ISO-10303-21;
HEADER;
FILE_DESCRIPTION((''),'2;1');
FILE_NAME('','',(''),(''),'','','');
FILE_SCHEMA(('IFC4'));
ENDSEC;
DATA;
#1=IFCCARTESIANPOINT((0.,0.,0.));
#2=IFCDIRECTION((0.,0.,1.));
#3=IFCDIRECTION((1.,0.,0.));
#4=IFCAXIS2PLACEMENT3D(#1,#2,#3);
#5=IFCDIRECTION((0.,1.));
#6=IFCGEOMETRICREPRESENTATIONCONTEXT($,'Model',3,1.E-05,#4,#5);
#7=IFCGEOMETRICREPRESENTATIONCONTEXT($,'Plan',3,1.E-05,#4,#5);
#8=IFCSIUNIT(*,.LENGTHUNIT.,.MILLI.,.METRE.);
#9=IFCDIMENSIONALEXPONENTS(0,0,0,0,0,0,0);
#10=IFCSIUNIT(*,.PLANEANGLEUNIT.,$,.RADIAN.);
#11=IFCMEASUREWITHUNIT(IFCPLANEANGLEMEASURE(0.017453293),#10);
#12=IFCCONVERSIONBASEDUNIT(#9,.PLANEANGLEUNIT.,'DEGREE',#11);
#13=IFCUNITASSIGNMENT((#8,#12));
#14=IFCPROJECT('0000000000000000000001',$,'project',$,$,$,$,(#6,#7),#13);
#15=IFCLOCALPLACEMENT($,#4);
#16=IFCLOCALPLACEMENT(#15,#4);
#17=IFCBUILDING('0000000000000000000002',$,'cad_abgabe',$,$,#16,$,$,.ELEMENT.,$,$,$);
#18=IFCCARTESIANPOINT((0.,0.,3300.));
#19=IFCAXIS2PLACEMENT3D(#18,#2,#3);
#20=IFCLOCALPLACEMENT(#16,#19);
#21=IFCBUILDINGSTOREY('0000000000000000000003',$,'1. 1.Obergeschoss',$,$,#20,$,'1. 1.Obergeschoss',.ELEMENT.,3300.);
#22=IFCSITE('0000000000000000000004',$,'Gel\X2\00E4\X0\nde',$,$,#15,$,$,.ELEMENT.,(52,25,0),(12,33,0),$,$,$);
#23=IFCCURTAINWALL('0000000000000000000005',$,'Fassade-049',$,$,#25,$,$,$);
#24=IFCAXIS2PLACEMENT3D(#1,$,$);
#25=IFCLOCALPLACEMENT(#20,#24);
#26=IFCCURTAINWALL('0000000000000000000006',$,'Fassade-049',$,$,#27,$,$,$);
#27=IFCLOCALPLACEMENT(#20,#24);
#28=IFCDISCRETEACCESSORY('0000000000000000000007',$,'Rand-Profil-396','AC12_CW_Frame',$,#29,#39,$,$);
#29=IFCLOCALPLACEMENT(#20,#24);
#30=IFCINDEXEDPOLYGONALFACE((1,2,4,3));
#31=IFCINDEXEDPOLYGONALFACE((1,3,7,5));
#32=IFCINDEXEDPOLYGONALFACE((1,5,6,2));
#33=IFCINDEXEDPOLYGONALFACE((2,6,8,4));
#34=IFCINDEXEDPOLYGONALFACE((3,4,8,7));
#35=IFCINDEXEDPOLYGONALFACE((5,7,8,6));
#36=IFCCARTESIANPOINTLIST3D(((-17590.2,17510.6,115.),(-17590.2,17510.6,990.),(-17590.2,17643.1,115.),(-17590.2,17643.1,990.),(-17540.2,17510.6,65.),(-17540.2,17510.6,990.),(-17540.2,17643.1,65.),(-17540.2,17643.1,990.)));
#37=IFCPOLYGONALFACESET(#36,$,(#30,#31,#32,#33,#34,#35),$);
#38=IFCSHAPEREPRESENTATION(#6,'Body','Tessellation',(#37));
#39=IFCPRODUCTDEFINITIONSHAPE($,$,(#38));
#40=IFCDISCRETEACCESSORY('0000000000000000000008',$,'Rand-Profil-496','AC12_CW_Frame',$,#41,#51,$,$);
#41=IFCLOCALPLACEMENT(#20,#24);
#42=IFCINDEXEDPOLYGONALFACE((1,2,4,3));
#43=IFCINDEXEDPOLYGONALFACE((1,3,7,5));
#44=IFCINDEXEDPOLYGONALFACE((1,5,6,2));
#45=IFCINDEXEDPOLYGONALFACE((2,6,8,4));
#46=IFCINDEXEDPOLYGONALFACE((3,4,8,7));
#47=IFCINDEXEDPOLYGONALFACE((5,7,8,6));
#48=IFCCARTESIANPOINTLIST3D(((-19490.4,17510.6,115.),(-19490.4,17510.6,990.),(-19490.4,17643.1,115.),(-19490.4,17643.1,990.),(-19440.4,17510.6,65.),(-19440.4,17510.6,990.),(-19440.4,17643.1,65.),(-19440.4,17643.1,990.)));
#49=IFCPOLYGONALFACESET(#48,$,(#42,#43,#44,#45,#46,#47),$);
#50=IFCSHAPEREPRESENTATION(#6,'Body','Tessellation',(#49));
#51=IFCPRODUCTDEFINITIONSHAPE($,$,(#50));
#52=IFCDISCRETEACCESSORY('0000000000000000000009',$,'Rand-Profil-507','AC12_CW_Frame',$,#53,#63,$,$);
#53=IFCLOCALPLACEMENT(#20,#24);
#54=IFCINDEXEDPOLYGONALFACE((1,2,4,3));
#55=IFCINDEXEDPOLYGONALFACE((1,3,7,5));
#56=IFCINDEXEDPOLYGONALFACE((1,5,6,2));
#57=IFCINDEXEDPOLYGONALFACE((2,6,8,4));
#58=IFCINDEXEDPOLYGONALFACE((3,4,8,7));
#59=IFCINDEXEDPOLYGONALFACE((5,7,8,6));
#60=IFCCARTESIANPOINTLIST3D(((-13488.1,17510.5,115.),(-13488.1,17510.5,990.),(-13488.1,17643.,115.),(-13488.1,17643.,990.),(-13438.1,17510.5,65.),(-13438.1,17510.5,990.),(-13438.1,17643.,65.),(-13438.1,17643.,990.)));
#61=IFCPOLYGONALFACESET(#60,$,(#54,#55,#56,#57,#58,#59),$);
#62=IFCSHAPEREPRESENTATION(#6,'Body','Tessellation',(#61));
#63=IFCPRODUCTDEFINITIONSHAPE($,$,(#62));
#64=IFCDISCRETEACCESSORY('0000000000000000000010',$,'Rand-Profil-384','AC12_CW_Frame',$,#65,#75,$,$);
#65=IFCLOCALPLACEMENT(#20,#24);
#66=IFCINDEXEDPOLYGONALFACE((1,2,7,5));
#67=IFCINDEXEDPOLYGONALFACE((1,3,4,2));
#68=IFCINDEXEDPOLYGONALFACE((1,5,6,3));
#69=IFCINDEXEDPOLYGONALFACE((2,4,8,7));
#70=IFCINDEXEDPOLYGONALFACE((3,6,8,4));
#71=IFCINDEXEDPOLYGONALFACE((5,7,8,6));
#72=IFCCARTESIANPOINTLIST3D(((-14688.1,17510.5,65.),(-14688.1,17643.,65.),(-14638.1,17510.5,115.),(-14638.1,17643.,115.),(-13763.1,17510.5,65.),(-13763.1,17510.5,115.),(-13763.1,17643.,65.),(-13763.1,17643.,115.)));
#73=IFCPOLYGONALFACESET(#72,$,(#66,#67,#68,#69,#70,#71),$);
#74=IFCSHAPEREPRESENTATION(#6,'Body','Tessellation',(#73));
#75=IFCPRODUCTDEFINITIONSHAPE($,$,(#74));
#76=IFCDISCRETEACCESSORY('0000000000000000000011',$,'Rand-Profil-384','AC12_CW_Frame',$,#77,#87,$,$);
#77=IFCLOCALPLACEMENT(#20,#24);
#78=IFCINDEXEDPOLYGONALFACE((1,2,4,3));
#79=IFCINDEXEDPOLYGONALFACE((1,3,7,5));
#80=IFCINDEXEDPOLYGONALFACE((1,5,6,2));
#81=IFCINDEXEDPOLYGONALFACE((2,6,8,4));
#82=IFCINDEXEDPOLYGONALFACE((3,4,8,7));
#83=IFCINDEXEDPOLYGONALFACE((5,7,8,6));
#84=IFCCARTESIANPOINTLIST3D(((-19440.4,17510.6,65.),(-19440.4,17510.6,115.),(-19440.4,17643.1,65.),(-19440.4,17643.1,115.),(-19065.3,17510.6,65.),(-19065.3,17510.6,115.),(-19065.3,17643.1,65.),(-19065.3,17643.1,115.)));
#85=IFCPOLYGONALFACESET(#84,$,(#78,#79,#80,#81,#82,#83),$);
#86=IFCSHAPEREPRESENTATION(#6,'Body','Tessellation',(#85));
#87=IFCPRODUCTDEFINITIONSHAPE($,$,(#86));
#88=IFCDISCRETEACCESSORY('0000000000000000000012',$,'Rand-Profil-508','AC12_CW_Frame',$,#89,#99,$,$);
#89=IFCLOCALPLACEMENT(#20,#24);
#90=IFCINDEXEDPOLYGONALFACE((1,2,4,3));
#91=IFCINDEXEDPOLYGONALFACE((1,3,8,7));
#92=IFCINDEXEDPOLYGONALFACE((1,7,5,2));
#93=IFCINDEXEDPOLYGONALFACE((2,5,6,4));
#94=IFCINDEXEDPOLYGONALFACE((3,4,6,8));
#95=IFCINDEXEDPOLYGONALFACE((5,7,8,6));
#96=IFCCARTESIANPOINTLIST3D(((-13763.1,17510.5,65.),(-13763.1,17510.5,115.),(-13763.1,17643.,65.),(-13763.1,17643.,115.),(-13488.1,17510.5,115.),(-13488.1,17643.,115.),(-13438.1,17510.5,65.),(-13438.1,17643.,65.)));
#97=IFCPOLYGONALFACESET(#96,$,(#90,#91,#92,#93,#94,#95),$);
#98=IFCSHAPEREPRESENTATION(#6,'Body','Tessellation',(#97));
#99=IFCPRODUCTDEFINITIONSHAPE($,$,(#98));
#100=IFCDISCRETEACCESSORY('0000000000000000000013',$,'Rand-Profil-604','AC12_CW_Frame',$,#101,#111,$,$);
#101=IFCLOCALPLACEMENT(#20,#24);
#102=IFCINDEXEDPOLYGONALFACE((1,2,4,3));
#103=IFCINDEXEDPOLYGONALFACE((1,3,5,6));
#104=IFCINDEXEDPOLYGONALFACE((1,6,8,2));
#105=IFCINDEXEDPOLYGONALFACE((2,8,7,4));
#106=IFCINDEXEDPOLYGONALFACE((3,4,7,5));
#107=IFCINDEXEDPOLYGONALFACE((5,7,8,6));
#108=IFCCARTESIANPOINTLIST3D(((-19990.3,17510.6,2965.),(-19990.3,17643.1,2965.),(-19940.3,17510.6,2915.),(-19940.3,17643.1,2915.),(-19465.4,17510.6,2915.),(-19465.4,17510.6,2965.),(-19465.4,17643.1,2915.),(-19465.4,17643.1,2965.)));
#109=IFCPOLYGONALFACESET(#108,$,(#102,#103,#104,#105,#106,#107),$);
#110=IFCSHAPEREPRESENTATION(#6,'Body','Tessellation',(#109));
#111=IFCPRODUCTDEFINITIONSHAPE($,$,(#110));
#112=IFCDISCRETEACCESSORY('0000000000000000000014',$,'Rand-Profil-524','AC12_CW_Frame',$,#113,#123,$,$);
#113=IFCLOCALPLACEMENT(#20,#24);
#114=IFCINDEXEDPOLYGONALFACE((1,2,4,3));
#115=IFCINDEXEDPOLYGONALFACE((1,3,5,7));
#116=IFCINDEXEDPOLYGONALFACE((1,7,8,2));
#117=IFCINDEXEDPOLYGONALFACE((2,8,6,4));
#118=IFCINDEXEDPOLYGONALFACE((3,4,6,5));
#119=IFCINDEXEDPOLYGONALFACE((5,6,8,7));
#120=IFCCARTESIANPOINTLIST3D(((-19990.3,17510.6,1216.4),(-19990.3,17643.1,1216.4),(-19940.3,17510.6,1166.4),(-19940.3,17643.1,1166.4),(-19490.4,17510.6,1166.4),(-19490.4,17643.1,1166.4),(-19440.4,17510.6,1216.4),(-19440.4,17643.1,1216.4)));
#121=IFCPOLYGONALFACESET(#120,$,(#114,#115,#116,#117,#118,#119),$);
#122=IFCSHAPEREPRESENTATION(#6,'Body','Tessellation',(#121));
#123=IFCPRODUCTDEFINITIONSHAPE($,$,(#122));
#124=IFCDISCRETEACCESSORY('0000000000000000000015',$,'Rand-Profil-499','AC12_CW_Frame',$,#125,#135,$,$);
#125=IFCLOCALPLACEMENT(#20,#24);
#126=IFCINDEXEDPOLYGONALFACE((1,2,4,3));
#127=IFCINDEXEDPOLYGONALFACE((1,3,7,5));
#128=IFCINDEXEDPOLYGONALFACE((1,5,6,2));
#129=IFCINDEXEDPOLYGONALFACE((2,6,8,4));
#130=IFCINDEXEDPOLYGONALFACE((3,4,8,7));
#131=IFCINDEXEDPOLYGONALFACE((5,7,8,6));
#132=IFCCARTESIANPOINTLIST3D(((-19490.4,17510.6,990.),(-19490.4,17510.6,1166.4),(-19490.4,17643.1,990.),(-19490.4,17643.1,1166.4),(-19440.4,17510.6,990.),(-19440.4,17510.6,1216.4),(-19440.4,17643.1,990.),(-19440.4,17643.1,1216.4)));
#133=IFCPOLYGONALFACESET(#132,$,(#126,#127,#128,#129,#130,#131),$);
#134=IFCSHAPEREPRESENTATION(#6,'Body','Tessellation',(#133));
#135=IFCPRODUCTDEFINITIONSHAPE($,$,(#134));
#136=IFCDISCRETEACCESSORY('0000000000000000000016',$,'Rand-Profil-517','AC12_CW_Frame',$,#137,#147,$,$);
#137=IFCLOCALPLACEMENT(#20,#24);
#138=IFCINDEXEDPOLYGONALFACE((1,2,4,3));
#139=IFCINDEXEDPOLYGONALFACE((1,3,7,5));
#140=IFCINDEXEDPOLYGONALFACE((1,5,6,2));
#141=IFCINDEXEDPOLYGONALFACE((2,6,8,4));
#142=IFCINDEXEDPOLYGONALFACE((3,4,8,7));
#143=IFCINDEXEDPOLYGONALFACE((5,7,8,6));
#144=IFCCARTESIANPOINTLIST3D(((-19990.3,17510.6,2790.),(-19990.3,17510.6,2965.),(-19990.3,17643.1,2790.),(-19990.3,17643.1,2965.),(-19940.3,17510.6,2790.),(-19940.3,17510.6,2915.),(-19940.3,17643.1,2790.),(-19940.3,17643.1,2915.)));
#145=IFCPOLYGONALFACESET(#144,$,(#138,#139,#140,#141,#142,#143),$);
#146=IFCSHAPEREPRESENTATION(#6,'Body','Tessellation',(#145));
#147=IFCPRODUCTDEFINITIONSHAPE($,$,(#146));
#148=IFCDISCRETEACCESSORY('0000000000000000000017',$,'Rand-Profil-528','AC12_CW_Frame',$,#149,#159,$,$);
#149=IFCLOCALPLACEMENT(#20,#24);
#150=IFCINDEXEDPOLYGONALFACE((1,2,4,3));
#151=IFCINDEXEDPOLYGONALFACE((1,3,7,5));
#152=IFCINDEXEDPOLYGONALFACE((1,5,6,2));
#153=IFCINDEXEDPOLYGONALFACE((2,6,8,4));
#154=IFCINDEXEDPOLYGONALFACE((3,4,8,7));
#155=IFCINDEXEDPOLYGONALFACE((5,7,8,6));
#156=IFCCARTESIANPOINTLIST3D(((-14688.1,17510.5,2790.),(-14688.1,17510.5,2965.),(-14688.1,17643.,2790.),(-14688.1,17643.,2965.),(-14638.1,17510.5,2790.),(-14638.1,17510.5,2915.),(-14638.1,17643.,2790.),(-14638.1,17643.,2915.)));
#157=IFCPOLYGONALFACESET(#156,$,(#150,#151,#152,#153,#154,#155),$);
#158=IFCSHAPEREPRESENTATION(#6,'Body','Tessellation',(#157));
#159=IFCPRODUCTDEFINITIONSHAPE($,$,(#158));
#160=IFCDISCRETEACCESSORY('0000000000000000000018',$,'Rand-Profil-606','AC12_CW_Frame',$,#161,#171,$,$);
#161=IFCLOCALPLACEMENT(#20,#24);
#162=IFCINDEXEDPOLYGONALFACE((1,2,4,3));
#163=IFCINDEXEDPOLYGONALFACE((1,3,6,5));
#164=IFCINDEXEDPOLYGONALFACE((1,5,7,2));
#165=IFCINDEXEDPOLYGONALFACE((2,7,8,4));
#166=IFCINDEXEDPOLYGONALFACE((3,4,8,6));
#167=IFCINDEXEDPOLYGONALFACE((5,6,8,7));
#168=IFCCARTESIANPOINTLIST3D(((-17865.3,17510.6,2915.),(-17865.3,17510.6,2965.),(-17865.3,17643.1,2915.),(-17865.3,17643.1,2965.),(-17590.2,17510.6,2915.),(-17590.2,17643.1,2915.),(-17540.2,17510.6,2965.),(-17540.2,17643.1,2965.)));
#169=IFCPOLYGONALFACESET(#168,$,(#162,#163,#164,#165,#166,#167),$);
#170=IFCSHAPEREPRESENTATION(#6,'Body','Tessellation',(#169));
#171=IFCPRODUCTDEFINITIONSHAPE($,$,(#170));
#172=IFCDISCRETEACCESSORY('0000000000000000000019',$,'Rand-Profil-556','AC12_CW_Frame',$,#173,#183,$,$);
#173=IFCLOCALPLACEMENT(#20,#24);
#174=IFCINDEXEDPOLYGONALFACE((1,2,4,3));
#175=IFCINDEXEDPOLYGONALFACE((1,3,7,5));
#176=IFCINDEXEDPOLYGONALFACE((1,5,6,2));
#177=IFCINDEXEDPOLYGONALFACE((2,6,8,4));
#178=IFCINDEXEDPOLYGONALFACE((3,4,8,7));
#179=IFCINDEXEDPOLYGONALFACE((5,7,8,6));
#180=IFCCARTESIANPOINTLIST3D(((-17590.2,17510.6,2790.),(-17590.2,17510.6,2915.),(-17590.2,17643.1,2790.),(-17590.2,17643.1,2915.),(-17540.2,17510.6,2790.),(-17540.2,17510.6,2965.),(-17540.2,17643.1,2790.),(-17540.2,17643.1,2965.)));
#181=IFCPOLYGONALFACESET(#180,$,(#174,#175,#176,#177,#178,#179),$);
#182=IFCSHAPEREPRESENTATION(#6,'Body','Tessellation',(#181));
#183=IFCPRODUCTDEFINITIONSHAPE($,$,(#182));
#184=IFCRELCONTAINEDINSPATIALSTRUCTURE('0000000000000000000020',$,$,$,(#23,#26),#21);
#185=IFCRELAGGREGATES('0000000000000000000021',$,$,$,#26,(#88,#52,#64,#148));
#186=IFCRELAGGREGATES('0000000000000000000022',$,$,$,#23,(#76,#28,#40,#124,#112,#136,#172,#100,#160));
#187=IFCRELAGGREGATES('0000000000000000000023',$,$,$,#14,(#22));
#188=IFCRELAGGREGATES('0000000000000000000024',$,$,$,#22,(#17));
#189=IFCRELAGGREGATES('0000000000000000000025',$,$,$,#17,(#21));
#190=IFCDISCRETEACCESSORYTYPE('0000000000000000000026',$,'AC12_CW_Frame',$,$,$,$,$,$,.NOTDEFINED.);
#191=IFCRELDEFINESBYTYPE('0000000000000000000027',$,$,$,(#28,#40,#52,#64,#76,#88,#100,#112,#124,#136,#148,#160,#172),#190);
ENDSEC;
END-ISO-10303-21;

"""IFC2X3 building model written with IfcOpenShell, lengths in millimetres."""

from ifc_helpers import new_model, entity, si_unit, converted_unit, direction, frame, origin_with_axes, place, context, project, spatial, polyline, outline, extrude, source, transform, mapped, type_object, element, aggregate, save


model = new_model("IFC2X3")

# Units and contexts
model_context = context("Model", 3, precision=1e-05, world=origin_with_axes(), true_north=direction((0.0, 1.0)))
plan_context = context("Plan", 3, precision=1e-05, world=origin_with_axes(), true_north=direction((0.0, 1.0)))
ifc_project = project(units=[si_unit("LENGTHUNIT", "METRE", prefix="MILLI"), converted_unit("PLANEANGLEUNIT", "DEGREE", entity("IfcPlaneAngleMeasure", 0.017453293), si_unit("PLANEANGLEUNIT", "RADIAN"), dimensions=[0, 0, 0, 0, 0, 0, 0])], contexts=[model_context, plan_context])

# Site, building, storey
site_placement = place(None, origin_with_axes())
site = spatial("IfcSite", under=ifc_project, at=site_placement, Name="Gelände", CompositionType="ELEMENT", RefLatitude=(52, 25, 0), RefLongitude=(12, 33, 0))
building_placement = place(site_placement, origin_with_axes())
building = spatial("IfcBuilding", under=site, at=building_placement, Name="cad_abgabe", CompositionType="ELEMENT")
storey_placement = place(building_placement, frame((0.0, 0.0, 3300.0), z_axis=(0.0, 0.0, 1.0), x_axis=(1.0, 0.0, 0.0)))
storey = spatial("IfcBuildingStorey", under=building, at=storey_placement, Name="1. 1.Obergeschoss", LongName="1. 1.Obergeschoss", CompositionType="ELEMENT", Elevation=3300.0)

# Curtain walls
curtain_wall_1_placement = place(storey_placement, frame((-19965.3, 17588.1, 90.0), z_axis=(0.0, 0.0, 1.0), x_axis=(1.0, 0.0, 0.0)))
curtain_wall_1 = element("IfcCurtainWall", 1, at=curtain_wall_1_placement, inside=storey, Name="Fassade-049")
discrete_accessory_type = type_object("IfcDiscreteAccessoryType", Name="AC12_CW_Frame")
curtain_wall_2_placement = place(storey_placement, frame((-14663.1, 17588.0, 90.0), z_axis=(0.0, 0.0, 1.0), x_axis=(1.0, 0.0, 0.0)))
curtain_wall_2 = element("IfcCurtainWall", 2, at=curtain_wall_2_placement, inside=storey, Name="Fassade-049")

# Discrete accessories
shared_shape_1 = source(origin_with_axes(), model_context, "Body", "SweptSolid", [
    extrude(outline(polyline([(0.0, 0.0), (925.0, 0.0), (925.0, -50.0), (50.0, -50.0), (0.0, 0.0)])), origin_with_axes(), (0.0, 0.0, 1.0), 132.5),
])
discrete_accessory_1_placement = place(storey_placement, frame((-17540.2, 17510.6, 65.0), z_axis=(0.0, 1.0, 0.0), x_axis=(0.0, 0.0, 1.0)))
discrete_accessory_1 = element("IfcDiscreteAccessory", 3, at=discrete_accessory_1_placement, type_object=discrete_accessory_type, Name="Rand-Profil-396", Description="AC12_CW_Frame", context=model_context, shape_type="MappedRepresentation", body=[
    mapped(shared_shape_1, transform((0.0, 0.0, 0.0), scale=1.0)),
])
discrete_accessory_2_placement = place(storey_placement, frame((-19440.4, 17510.6, 65.0), z_axis=(0.0, 1.0, 0.0), x_axis=(0.0, 0.0, 1.0)))
discrete_accessory_2 = element("IfcDiscreteAccessory", 4, at=discrete_accessory_2_placement, type_object=discrete_accessory_type, Name="Rand-Profil-496", Description="AC12_CW_Frame", context=model_context, shape_type="MappedRepresentation", body=[
    mapped(shared_shape_1, transform((0.0, 0.0, 0.0), scale=1.0)),
])
discrete_accessory_3_placement = place(storey_placement, frame((-13438.1, 17510.5, 65.0), z_axis=(0.0, 1.0, 0.0), x_axis=(0.0, 0.0, 1.0)))
discrete_accessory_3 = element("IfcDiscreteAccessory", 5, at=discrete_accessory_3_placement, type_object=discrete_accessory_type, Name="Rand-Profil-507", Description="AC12_CW_Frame", context=model_context, shape_type="MappedRepresentation", body=[
    mapped(shared_shape_1, transform((0.0, 0.0, 0.0), scale=1.0)),
])
discrete_accessory_4_placement = place(storey_placement, frame((-14688.1, 17510.5, 65.0), z_axis=(0.0, 1.0, 0.0), x_axis=(1.0, 0.0, 0.0)))
discrete_accessory_4 = element("IfcDiscreteAccessory", 6, at=discrete_accessory_4_placement, type_object=discrete_accessory_type, Name="Rand-Profil-384", Description="AC12_CW_Frame", context=model_context, shape_type="MappedRepresentation", body=[
    mapped(shared_shape_1, transform((0.0, 0.0, 0.0), scale=1.0)),
])
shared_shape_2 = source(origin_with_axes(), model_context, "Body", "SweptSolid", [
    extrude(outline(polyline([(0.0, 0.0), (375.1, 0.0), (375.1, -132.5), (0.0, -132.5), (0.0, 0.0)])), origin_with_axes(), (0.0, 0.0, 1.0), 50.0),
])
discrete_accessory_5_placement = place(storey_placement, frame((-19440.4, 17510.6, 115.0), z_axis=(0.0, 0.0, -1.0), x_axis=(1.0, 0.0, 0.0)))
discrete_accessory_5 = element("IfcDiscreteAccessory", 7, at=discrete_accessory_5_placement, type_object=discrete_accessory_type, Name="Rand-Profil-384", Description="AC12_CW_Frame", context=model_context, shape_type="MappedRepresentation", body=[
    mapped(shared_shape_2, transform((0.0, 0.0, 0.0), scale=1.0)),
])
shared_shape_3 = source(origin_with_axes(), model_context, "Body", "SweptSolid", [
    extrude(outline(polyline([(0.0, 0.0), (325.0, 0.0), (275.0, -50.0), (0.0, -50.0), (0.0, 0.0)])), origin_with_axes(), (0.0, 0.0, 1.0), 132.5),
])
discrete_accessory_6_placement = place(storey_placement, frame((-13763.1, 17510.5, 65.0), z_axis=(0.0, 1.0, 0.0), x_axis=(1.0, 0.0, 0.0)))
discrete_accessory_6 = element("IfcDiscreteAccessory", 8, at=discrete_accessory_6_placement, type_object=discrete_accessory_type, Name="Rand-Profil-508", Description="AC12_CW_Frame", context=model_context, shape_type="MappedRepresentation", body=[
    mapped(shared_shape_3, transform((0.0, 0.0, 0.0), scale=1.0)),
])
shared_shape_4 = source(origin_with_axes(), model_context, "Body", "SweptSolid", [
    extrude(outline(polyline([(0.0, 0.0), (524.9, 0.0), (474.9, -50.0), (0.0, -50.0), (0.0, 0.0)])), origin_with_axes(), (0.0, 0.0, 1.0), 132.5),
])
discrete_accessory_7_placement = place(storey_placement, frame((-19465.4, 17510.6, 2965.0), z_axis=(0.0, 1.0, 0.0), x_axis=(-1.0, 0.0, 0.0)))
discrete_accessory_7 = element("IfcDiscreteAccessory", 9, at=discrete_accessory_7_placement, type_object=discrete_accessory_type, Name="Rand-Profil-604", Description="AC12_CW_Frame", context=model_context, shape_type="MappedRepresentation", body=[
    mapped(shared_shape_4, transform((0.0, 0.0, 0.0), scale=1.0)),
])
shared_shape_5 = source(origin_with_axes(), model_context, "Body", "SweptSolid", [
    extrude(outline(polyline([(0.0, 0.0), (449.9, 0.0), (499.9, -50.0), (-50.0, -50.0), (0.0, 0.0)])), origin_with_axes(), (0.0, 0.0, 1.0), 132.5),
])
discrete_accessory_8_placement = place(storey_placement, frame((-19940.3, 17510.6, 1166.4), z_axis=(0.0, 1.0, 0.0), x_axis=(1.0, 0.0, 0.0)))
discrete_accessory_8 = element("IfcDiscreteAccessory", 10, at=discrete_accessory_8_placement, type_object=discrete_accessory_type, Name="Rand-Profil-524", Description="AC12_CW_Frame", context=model_context, shape_type="MappedRepresentation", body=[
    mapped(shared_shape_5, transform((0.0, 0.0, 0.0), scale=1.0)),
])
shared_shape_6 = source(origin_with_axes(), model_context, "Body", "SweptSolid", [
    extrude(outline(polyline([(0.0, 0.0), (226.4, 0.0), (176.4, -50.0), (0.0, -50.0), (0.0, 0.0)])), origin_with_axes(), (0.0, 0.0, 1.0), 132.5),
])
discrete_accessory_9_placement = place(storey_placement, frame((-19440.4, 17510.6, 990.0), z_axis=(0.0, 1.0, 0.0), x_axis=(0.0, 0.0, 1.0)))
discrete_accessory_9 = element("IfcDiscreteAccessory", 11, at=discrete_accessory_9_placement, type_object=discrete_accessory_type, Name="Rand-Profil-499", Description="AC12_CW_Frame", context=model_context, shape_type="MappedRepresentation", body=[
    mapped(shared_shape_6, transform((0.0, 0.0, 0.0), scale=1.0)),
])
shared_shape_7 = source(origin_with_axes(), model_context, "Body", "SweptSolid", [
    extrude(outline(polyline([(0.0, 0.0), (125.0, 0.0), (175.0, -50.0), (0.0, -50.0), (0.0, 0.0)])), origin_with_axes(), (0.0, 0.0, 1.0), 132.5),
])
discrete_accessory_10_placement = place(storey_placement, frame((-19940.3, 17510.6, 2790.0), z_axis=(0.0, 1.0, 0.0), x_axis=(0.0, 0.0, 1.0)))
discrete_accessory_10 = element("IfcDiscreteAccessory", 12, at=discrete_accessory_10_placement, type_object=discrete_accessory_type, Name="Rand-Profil-517", Description="AC12_CW_Frame", context=model_context, shape_type="MappedRepresentation", body=[
    mapped(shared_shape_7, transform((0.0, 0.0, 0.0), scale=1.0)),
])
discrete_accessory_11_placement = place(storey_placement, frame((-14638.1, 17510.5, 2790.0), z_axis=(0.0, 1.0, 0.0), x_axis=(0.0, 0.0, 1.0)))
discrete_accessory_11 = element("IfcDiscreteAccessory", 13, at=discrete_accessory_11_placement, type_object=discrete_accessory_type, Name="Rand-Profil-528", Description="AC12_CW_Frame", context=model_context, shape_type="MappedRepresentation", body=[
    mapped(shared_shape_7, transform((0.0, 0.0, 0.0), scale=1.0)),
])
shared_shape_8 = source(origin_with_axes(), model_context, "Body", "SweptSolid", [
    extrude(outline(polyline([(0.0, 0.0), (325.1, 0.0), (325.1, -50.0), (50.0, -50.0), (0.0, 0.0)])), origin_with_axes(), (0.0, 0.0, 1.0), 132.5),
])
discrete_accessory_12_placement = place(storey_placement, frame((-17540.2, 17510.6, 2965.0), z_axis=(0.0, 1.0, 0.0), x_axis=(-1.0, 0.0, 0.0)))
discrete_accessory_12 = element("IfcDiscreteAccessory", 14, at=discrete_accessory_12_placement, type_object=discrete_accessory_type, Name="Rand-Profil-606", Description="AC12_CW_Frame", context=model_context, shape_type="MappedRepresentation", body=[
    mapped(shared_shape_8, transform((0.0, 0.0, 0.0), scale=1.0)),
])
shared_shape_9 = source(origin_with_axes(), model_context, "Body", "SweptSolid", [
    extrude(outline(polyline([(0.0, 0.0), (175.0, 0.0), (125.0, -50.0), (0.0, -50.0), (0.0, 0.0)])), origin_with_axes(), (0.0, 0.0, 1.0), 132.5),
])
discrete_accessory_13_placement = place(storey_placement, frame((-17540.2, 17510.6, 2790.0), z_axis=(0.0, 1.0, 0.0), x_axis=(0.0, 0.0, 1.0)))
discrete_accessory_13 = element("IfcDiscreteAccessory", 15, at=discrete_accessory_13_placement, type_object=discrete_accessory_type, Name="Rand-Profil-556", Description="AC12_CW_Frame", context=model_context, shape_type="MappedRepresentation", body=[
    mapped(shared_shape_9, transform((0.0, 0.0, 0.0), scale=1.0)),
])
aggregate(curtain_wall_2, [discrete_accessory_6, discrete_accessory_3, discrete_accessory_4, discrete_accessory_11])
aggregate(curtain_wall_1, [discrete_accessory_5, discrete_accessory_1, discrete_accessory_2, discrete_accessory_9, discrete_accessory_8, discrete_accessory_10, discrete_accessory_13, discrete_accessory_7, discrete_accessory_12])

save(model, "model.ifc")
